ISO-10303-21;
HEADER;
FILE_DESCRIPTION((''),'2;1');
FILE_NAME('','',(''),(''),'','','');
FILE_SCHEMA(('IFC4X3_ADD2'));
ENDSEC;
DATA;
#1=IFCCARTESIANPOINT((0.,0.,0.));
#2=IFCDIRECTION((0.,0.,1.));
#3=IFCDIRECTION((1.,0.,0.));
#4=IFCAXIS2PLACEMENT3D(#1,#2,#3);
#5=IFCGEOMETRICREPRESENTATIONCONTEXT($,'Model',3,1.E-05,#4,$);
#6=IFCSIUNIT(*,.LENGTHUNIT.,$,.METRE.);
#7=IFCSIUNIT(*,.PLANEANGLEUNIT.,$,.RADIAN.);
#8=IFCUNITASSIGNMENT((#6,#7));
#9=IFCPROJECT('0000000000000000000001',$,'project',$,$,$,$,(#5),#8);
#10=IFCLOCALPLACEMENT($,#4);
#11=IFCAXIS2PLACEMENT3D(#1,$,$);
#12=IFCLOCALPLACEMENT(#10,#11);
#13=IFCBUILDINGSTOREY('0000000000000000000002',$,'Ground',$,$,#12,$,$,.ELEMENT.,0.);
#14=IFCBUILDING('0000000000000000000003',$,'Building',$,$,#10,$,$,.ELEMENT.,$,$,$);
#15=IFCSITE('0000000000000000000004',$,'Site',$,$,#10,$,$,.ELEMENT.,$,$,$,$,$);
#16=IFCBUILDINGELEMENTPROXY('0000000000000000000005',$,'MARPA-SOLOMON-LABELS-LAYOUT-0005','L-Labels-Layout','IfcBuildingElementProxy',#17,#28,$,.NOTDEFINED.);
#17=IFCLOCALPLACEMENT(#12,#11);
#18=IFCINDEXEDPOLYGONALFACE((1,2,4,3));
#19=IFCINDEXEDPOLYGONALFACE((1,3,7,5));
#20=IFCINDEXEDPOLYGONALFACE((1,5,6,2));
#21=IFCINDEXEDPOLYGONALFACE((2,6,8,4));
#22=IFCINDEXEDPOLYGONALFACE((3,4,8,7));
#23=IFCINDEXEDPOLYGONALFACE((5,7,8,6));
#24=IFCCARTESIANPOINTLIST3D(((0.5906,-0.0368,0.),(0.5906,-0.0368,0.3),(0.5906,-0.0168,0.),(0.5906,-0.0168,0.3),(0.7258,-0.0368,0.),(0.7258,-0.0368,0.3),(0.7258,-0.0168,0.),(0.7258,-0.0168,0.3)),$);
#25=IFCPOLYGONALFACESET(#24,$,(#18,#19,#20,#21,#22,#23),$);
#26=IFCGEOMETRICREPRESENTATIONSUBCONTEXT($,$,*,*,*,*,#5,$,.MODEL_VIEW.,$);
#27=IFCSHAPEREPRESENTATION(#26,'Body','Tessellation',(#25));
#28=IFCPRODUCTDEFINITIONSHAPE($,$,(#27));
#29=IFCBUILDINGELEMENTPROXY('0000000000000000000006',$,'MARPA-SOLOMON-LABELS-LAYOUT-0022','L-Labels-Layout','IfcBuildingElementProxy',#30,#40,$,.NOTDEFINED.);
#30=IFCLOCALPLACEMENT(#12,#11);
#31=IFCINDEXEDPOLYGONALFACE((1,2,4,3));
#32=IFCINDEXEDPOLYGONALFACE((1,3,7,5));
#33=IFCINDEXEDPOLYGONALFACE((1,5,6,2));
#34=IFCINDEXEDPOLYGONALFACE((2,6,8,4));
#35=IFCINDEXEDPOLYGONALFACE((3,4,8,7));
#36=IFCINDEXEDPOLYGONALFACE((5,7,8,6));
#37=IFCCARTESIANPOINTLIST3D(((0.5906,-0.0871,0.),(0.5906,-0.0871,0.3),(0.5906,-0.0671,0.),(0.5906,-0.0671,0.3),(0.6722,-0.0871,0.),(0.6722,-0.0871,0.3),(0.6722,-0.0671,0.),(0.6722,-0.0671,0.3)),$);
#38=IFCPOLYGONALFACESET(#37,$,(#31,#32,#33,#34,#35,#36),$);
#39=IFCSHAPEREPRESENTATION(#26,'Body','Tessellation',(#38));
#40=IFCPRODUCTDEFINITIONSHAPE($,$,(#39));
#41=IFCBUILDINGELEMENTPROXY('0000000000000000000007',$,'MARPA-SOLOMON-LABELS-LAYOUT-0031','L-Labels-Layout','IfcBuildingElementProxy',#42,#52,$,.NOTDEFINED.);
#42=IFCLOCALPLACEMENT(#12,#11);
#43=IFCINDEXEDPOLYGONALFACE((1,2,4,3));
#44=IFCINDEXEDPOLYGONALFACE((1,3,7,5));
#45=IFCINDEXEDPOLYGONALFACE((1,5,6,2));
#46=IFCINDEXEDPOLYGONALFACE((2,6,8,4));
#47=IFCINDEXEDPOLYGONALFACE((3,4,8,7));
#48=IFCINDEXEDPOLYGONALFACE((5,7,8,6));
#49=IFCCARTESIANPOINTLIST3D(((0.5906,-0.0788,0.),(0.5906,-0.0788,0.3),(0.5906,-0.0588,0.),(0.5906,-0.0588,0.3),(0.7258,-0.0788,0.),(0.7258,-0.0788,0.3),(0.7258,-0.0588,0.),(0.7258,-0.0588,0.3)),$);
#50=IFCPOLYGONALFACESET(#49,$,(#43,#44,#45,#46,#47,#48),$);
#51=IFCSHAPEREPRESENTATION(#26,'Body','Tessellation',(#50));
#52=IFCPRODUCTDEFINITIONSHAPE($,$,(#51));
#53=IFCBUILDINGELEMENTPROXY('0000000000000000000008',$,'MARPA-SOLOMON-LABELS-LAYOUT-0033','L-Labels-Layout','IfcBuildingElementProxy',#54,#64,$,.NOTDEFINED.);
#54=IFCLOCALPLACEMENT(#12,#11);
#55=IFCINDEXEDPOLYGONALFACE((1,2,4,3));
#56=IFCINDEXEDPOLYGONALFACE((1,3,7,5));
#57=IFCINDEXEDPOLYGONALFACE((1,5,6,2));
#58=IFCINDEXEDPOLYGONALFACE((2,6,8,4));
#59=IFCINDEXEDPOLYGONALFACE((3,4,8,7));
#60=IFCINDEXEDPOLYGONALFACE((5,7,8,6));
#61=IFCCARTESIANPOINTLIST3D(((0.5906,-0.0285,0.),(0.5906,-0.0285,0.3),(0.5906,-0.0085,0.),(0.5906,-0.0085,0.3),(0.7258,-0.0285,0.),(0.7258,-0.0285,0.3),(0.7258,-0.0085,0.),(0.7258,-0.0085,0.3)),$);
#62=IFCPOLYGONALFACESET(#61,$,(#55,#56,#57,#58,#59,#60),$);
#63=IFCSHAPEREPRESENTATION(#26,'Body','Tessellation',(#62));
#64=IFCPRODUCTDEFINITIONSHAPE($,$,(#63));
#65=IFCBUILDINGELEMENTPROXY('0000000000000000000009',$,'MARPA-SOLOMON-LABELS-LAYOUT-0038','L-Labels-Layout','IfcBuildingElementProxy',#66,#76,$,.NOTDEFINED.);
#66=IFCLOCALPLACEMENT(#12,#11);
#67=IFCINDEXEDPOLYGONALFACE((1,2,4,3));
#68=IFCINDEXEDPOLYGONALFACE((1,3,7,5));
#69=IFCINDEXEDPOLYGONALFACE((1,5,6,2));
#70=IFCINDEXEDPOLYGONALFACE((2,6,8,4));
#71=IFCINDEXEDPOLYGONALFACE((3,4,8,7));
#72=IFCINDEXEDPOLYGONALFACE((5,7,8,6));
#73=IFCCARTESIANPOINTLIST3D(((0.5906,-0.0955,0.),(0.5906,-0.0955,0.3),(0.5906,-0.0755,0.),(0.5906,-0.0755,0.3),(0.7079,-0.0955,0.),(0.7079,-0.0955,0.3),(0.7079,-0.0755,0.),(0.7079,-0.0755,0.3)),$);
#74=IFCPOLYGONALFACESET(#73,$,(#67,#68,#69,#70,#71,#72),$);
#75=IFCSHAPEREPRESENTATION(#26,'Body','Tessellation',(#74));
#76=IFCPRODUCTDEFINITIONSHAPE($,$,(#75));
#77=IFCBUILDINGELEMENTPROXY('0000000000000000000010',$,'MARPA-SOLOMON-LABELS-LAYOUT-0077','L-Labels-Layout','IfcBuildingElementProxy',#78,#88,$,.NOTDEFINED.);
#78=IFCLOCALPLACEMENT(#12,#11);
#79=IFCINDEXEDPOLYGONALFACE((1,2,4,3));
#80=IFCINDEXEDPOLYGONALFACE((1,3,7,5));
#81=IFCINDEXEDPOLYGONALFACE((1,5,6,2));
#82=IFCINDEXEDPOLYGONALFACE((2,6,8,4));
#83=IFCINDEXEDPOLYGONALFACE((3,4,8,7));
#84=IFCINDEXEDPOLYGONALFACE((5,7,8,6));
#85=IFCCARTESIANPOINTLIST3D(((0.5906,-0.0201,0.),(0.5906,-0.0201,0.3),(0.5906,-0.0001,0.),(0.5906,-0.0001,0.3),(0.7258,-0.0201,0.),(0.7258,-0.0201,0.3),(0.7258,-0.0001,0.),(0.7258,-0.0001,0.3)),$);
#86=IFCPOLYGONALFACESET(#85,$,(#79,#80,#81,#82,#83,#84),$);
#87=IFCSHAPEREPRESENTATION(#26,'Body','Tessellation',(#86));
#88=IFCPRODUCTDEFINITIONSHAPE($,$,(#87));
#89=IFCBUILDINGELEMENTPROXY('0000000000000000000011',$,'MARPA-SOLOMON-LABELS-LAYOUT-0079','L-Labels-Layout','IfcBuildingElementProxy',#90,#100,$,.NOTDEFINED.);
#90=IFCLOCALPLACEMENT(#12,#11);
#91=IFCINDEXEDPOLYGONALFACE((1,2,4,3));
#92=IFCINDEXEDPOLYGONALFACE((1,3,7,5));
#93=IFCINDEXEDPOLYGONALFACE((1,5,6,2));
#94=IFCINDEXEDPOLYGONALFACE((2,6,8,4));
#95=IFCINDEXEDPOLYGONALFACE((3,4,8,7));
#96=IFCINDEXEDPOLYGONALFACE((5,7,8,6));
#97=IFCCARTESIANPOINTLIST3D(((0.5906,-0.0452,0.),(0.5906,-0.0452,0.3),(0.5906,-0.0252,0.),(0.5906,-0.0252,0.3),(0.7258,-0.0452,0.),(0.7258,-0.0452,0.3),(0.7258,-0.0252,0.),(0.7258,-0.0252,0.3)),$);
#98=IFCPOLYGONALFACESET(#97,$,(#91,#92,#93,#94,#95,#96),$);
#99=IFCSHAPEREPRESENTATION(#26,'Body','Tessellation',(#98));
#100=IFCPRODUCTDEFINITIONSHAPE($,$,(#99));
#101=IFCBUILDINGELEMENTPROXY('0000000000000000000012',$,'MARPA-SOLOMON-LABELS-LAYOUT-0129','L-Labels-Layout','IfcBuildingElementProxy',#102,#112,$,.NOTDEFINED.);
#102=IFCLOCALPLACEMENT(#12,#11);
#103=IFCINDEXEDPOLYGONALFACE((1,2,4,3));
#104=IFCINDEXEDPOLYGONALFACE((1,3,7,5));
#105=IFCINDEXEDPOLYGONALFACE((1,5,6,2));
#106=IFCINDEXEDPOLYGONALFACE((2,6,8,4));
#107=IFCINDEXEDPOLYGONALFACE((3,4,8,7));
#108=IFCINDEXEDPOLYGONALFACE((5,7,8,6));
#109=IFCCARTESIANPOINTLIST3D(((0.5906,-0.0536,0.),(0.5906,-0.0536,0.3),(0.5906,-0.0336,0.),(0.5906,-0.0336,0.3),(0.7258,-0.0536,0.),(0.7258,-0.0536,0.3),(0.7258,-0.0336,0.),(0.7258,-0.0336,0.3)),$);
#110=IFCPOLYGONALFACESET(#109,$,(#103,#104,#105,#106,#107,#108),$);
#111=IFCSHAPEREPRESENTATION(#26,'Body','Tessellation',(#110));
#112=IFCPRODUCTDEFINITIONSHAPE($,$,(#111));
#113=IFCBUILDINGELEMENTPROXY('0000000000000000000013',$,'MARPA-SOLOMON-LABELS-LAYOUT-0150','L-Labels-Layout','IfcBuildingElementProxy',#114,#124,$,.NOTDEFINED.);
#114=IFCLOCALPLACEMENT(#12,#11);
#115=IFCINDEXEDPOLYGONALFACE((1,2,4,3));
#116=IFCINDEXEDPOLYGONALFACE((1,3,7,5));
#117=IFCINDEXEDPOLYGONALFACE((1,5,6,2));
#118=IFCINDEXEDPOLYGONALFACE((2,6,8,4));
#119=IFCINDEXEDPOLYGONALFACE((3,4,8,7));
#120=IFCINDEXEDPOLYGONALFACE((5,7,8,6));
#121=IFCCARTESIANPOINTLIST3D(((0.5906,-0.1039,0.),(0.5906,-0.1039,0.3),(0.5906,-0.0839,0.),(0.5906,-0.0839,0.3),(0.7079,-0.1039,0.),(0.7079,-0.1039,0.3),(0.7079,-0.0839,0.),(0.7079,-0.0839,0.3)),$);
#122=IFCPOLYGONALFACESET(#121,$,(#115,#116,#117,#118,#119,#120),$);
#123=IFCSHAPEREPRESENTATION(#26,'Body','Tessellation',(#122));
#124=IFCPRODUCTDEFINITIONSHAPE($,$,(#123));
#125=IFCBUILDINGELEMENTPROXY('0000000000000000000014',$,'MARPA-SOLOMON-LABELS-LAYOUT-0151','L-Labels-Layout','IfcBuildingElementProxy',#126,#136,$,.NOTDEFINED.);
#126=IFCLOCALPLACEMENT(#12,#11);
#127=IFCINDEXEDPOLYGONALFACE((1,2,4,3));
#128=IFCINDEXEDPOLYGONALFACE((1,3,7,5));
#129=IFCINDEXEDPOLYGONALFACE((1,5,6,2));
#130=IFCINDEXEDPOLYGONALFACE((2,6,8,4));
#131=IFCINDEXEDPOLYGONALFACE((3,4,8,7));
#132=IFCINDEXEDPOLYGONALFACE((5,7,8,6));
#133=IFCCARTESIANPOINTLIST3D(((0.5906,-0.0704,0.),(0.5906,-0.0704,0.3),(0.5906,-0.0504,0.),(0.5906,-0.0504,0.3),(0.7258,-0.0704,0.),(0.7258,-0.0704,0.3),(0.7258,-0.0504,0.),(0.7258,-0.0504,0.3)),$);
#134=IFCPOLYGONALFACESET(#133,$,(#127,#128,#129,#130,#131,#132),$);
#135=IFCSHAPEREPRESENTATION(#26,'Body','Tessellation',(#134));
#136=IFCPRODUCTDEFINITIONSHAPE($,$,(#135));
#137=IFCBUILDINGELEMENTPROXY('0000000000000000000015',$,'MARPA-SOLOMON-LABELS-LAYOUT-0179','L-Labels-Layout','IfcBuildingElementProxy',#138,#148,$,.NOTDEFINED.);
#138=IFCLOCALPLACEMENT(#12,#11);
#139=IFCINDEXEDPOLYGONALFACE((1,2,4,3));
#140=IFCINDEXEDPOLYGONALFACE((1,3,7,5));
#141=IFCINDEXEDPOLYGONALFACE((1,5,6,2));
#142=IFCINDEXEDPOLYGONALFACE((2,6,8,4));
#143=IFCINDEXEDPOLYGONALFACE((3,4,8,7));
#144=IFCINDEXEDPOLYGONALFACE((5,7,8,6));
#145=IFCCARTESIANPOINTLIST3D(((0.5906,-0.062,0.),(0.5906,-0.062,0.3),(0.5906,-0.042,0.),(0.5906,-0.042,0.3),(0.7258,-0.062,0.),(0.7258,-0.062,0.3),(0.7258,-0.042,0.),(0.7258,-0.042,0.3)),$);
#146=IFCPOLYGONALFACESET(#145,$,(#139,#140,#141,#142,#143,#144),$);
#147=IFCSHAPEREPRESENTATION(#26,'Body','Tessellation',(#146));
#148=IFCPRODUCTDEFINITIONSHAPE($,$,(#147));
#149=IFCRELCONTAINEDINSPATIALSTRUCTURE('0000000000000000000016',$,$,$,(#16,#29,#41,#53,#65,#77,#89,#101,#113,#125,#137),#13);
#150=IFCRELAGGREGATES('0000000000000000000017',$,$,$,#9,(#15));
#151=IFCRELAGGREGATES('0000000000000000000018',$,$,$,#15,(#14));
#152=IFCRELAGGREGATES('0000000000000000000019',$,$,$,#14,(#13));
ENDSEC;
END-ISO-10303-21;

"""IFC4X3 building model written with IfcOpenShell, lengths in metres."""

from ifc_helpers import new_model, si_unit, frame, frame_2d, origin, origin_with_axes, place, context, subcontext, project, spatial, rectangle, extrude, element, save


model = new_model("IFC4X3")

# Units and contexts
model_context = context("Model", 3, precision=1e-05, world=origin_with_axes())
sub_context = subcontext(model_context, None, None, "MODEL_VIEW")
ifc_project = project(units=[si_unit("LENGTHUNIT", "METRE"), si_unit("PLANEANGLEUNIT", "RADIAN")], contexts=[model_context])

# Site, building, storey
placement = place(None, origin_with_axes())
site = spatial("IfcSite", under=ifc_project, at=placement, Name="Site", CompositionType="ELEMENT")
building = spatial("IfcBuilding", under=site, at=placement, Name="Building", CompositionType="ELEMENT")
storey_placement = place(placement, origin())
storey = spatial("IfcBuildingStorey", under=building, at=storey_placement, Name="Ground", CompositionType="ELEMENT", Elevation=0.0)

# Building element proxies
proxy_1_placement = place(placement, frame((0.5906, -0.0368, 0.0)))
element("IfcBuildingElementProxy", 1, at=proxy_1_placement, inside=storey, Name="MARPA-SOLOMON-LABELS-LAYOUT-0005", Description="L-Labels-Layout", ObjectType="IfcBuildingElementProxy", PredefinedType="NOTDEFINED", context=sub_context, shape_type="SweptSolid", body=[
    extrude(rectangle(XDim=0.1352, YDim=0.02, at=frame_2d((0.0676, 0.01))), origin(), (0.0, 0.0, 1.0), 0.3),
])
for number, where, name in (
    (2, (0.5906, -0.0871, 0.0), "MARPA-SOLOMON-LABELS-LAYOUT-0022"),
):
    element("IfcBuildingElementProxy", number, at=place(placement, frame(where)), inside=storey, Name=name, Description="L-Labels-Layout", ObjectType="IfcBuildingElementProxy", PredefinedType="NOTDEFINED", context=sub_context, shape_type="SweptSolid", body=[
        extrude(rectangle(XDim=0.0817, YDim=0.02, at=frame_2d((0.0408, 0.01))), origin(), (0.0, 0.0, 1.0), 0.3),
    ])
for number, where, name in (
    (3, (0.5906, -0.0788, 0.0), "MARPA-SOLOMON-LABELS-LAYOUT-0031"),
    (4, (0.5906, -0.0285, 0.0), "MARPA-SOLOMON-LABELS-LAYOUT-0033"),
):
    element("IfcBuildingElementProxy", number, at=place(placement, frame(where)), inside=storey, Name=name, Description="L-Labels-Layout", ObjectType="IfcBuildingElementProxy", PredefinedType="NOTDEFINED", context=sub_context, shape_type="SweptSolid", body=[
        extrude(rectangle(XDim=0.1352, YDim=0.02, at=frame_2d((0.0676, 0.01))), origin(), (0.0, 0.0, 1.0), 0.3),
    ])
proxy_2_placement = place(placement, frame((0.5906, -0.0955, 0.0)))
element("IfcBuildingElementProxy", 5, at=proxy_2_placement, inside=storey, Name="MARPA-SOLOMON-LABELS-LAYOUT-0038", Description="L-Labels-Layout", ObjectType="IfcBuildingElementProxy", PredefinedType="NOTDEFINED", context=sub_context, shape_type="SweptSolid", body=[
    extrude(rectangle(XDim=0.1174, YDim=0.02, at=frame_2d((0.0587, 0.01))), origin(), (0.0, 0.0, 1.0), 0.3),
])
for number, where, name in (
    (6, (0.5906, -0.0201, 0.0), "MARPA-SOLOMON-LABELS-LAYOUT-0077"),
    (7, (0.5906, -0.0452, 0.0), "MARPA-SOLOMON-LABELS-LAYOUT-0079"),
    (8, (0.5906, -0.0536, 0.0), "MARPA-SOLOMON-LABELS-LAYOUT-0129"),
):
    element("IfcBuildingElementProxy", number, at=place(placement, frame(where)), inside=storey, Name=name, Description="L-Labels-Layout", ObjectType="IfcBuildingElementProxy", PredefinedType="NOTDEFINED", context=sub_context, shape_type="SweptSolid", body=[
        extrude(rectangle(XDim=0.1352, YDim=0.02, at=frame_2d((0.0676, 0.01))), origin(), (0.0, 0.0, 1.0), 0.3),
    ])
proxy_3_placement = place(placement, frame((0.5906, -0.1039, 0.0)))
element("IfcBuildingElementProxy", 9, at=proxy_3_placement, inside=storey, Name="MARPA-SOLOMON-LABELS-LAYOUT-0150", Description="L-Labels-Layout", ObjectType="IfcBuildingElementProxy", PredefinedType="NOTDEFINED", context=sub_context, shape_type="SweptSolid", body=[
    extrude(rectangle(XDim=0.1174, YDim=0.02, at=frame_2d((0.0587, 0.01))), origin(), (0.0, 0.0, 1.0), 0.3),
])
for number, where, name in (
    (10, (0.5906, -0.0704, 0.0), "MARPA-SOLOMON-LABELS-LAYOUT-0151"),
):
    element("IfcBuildingElementProxy", number, at=place(placement, frame(where)), inside=storey, Name=name, Description="L-Labels-Layout", ObjectType="IfcBuildingElementProxy", PredefinedType="NOTDEFINED", context=sub_context, shape_type="SweptSolid", body=[
        extrude(rectangle(XDim=0.1352, YDim=0.02, at=frame_2d((0.0676, 0.01))), origin(), (0.0, 0.0, 1.0), 0.3),
    ])
for number, where, name in (
    (11, (0.5906, -0.062, 0.0), "MARPA-SOLOMON-LABELS-LAYOUT-0179"),
):
    element("IfcBuildingElementProxy", number, at=place(placement, frame(where)), inside=storey, Name=name, Description="L-Labels-Layout", ObjectType="IfcBuildingElementProxy", PredefinedType="NOTDEFINED", context=sub_context, shape_type="SweptSolid", body=[
        extrude(rectangle(XDim=0.1352, YDim=0.02, at=frame_2d((0.0676, 0.01))), origin(), (0.0, 0.0, 1.0), 0.3),
    ])

save(model, "model.ifc")
